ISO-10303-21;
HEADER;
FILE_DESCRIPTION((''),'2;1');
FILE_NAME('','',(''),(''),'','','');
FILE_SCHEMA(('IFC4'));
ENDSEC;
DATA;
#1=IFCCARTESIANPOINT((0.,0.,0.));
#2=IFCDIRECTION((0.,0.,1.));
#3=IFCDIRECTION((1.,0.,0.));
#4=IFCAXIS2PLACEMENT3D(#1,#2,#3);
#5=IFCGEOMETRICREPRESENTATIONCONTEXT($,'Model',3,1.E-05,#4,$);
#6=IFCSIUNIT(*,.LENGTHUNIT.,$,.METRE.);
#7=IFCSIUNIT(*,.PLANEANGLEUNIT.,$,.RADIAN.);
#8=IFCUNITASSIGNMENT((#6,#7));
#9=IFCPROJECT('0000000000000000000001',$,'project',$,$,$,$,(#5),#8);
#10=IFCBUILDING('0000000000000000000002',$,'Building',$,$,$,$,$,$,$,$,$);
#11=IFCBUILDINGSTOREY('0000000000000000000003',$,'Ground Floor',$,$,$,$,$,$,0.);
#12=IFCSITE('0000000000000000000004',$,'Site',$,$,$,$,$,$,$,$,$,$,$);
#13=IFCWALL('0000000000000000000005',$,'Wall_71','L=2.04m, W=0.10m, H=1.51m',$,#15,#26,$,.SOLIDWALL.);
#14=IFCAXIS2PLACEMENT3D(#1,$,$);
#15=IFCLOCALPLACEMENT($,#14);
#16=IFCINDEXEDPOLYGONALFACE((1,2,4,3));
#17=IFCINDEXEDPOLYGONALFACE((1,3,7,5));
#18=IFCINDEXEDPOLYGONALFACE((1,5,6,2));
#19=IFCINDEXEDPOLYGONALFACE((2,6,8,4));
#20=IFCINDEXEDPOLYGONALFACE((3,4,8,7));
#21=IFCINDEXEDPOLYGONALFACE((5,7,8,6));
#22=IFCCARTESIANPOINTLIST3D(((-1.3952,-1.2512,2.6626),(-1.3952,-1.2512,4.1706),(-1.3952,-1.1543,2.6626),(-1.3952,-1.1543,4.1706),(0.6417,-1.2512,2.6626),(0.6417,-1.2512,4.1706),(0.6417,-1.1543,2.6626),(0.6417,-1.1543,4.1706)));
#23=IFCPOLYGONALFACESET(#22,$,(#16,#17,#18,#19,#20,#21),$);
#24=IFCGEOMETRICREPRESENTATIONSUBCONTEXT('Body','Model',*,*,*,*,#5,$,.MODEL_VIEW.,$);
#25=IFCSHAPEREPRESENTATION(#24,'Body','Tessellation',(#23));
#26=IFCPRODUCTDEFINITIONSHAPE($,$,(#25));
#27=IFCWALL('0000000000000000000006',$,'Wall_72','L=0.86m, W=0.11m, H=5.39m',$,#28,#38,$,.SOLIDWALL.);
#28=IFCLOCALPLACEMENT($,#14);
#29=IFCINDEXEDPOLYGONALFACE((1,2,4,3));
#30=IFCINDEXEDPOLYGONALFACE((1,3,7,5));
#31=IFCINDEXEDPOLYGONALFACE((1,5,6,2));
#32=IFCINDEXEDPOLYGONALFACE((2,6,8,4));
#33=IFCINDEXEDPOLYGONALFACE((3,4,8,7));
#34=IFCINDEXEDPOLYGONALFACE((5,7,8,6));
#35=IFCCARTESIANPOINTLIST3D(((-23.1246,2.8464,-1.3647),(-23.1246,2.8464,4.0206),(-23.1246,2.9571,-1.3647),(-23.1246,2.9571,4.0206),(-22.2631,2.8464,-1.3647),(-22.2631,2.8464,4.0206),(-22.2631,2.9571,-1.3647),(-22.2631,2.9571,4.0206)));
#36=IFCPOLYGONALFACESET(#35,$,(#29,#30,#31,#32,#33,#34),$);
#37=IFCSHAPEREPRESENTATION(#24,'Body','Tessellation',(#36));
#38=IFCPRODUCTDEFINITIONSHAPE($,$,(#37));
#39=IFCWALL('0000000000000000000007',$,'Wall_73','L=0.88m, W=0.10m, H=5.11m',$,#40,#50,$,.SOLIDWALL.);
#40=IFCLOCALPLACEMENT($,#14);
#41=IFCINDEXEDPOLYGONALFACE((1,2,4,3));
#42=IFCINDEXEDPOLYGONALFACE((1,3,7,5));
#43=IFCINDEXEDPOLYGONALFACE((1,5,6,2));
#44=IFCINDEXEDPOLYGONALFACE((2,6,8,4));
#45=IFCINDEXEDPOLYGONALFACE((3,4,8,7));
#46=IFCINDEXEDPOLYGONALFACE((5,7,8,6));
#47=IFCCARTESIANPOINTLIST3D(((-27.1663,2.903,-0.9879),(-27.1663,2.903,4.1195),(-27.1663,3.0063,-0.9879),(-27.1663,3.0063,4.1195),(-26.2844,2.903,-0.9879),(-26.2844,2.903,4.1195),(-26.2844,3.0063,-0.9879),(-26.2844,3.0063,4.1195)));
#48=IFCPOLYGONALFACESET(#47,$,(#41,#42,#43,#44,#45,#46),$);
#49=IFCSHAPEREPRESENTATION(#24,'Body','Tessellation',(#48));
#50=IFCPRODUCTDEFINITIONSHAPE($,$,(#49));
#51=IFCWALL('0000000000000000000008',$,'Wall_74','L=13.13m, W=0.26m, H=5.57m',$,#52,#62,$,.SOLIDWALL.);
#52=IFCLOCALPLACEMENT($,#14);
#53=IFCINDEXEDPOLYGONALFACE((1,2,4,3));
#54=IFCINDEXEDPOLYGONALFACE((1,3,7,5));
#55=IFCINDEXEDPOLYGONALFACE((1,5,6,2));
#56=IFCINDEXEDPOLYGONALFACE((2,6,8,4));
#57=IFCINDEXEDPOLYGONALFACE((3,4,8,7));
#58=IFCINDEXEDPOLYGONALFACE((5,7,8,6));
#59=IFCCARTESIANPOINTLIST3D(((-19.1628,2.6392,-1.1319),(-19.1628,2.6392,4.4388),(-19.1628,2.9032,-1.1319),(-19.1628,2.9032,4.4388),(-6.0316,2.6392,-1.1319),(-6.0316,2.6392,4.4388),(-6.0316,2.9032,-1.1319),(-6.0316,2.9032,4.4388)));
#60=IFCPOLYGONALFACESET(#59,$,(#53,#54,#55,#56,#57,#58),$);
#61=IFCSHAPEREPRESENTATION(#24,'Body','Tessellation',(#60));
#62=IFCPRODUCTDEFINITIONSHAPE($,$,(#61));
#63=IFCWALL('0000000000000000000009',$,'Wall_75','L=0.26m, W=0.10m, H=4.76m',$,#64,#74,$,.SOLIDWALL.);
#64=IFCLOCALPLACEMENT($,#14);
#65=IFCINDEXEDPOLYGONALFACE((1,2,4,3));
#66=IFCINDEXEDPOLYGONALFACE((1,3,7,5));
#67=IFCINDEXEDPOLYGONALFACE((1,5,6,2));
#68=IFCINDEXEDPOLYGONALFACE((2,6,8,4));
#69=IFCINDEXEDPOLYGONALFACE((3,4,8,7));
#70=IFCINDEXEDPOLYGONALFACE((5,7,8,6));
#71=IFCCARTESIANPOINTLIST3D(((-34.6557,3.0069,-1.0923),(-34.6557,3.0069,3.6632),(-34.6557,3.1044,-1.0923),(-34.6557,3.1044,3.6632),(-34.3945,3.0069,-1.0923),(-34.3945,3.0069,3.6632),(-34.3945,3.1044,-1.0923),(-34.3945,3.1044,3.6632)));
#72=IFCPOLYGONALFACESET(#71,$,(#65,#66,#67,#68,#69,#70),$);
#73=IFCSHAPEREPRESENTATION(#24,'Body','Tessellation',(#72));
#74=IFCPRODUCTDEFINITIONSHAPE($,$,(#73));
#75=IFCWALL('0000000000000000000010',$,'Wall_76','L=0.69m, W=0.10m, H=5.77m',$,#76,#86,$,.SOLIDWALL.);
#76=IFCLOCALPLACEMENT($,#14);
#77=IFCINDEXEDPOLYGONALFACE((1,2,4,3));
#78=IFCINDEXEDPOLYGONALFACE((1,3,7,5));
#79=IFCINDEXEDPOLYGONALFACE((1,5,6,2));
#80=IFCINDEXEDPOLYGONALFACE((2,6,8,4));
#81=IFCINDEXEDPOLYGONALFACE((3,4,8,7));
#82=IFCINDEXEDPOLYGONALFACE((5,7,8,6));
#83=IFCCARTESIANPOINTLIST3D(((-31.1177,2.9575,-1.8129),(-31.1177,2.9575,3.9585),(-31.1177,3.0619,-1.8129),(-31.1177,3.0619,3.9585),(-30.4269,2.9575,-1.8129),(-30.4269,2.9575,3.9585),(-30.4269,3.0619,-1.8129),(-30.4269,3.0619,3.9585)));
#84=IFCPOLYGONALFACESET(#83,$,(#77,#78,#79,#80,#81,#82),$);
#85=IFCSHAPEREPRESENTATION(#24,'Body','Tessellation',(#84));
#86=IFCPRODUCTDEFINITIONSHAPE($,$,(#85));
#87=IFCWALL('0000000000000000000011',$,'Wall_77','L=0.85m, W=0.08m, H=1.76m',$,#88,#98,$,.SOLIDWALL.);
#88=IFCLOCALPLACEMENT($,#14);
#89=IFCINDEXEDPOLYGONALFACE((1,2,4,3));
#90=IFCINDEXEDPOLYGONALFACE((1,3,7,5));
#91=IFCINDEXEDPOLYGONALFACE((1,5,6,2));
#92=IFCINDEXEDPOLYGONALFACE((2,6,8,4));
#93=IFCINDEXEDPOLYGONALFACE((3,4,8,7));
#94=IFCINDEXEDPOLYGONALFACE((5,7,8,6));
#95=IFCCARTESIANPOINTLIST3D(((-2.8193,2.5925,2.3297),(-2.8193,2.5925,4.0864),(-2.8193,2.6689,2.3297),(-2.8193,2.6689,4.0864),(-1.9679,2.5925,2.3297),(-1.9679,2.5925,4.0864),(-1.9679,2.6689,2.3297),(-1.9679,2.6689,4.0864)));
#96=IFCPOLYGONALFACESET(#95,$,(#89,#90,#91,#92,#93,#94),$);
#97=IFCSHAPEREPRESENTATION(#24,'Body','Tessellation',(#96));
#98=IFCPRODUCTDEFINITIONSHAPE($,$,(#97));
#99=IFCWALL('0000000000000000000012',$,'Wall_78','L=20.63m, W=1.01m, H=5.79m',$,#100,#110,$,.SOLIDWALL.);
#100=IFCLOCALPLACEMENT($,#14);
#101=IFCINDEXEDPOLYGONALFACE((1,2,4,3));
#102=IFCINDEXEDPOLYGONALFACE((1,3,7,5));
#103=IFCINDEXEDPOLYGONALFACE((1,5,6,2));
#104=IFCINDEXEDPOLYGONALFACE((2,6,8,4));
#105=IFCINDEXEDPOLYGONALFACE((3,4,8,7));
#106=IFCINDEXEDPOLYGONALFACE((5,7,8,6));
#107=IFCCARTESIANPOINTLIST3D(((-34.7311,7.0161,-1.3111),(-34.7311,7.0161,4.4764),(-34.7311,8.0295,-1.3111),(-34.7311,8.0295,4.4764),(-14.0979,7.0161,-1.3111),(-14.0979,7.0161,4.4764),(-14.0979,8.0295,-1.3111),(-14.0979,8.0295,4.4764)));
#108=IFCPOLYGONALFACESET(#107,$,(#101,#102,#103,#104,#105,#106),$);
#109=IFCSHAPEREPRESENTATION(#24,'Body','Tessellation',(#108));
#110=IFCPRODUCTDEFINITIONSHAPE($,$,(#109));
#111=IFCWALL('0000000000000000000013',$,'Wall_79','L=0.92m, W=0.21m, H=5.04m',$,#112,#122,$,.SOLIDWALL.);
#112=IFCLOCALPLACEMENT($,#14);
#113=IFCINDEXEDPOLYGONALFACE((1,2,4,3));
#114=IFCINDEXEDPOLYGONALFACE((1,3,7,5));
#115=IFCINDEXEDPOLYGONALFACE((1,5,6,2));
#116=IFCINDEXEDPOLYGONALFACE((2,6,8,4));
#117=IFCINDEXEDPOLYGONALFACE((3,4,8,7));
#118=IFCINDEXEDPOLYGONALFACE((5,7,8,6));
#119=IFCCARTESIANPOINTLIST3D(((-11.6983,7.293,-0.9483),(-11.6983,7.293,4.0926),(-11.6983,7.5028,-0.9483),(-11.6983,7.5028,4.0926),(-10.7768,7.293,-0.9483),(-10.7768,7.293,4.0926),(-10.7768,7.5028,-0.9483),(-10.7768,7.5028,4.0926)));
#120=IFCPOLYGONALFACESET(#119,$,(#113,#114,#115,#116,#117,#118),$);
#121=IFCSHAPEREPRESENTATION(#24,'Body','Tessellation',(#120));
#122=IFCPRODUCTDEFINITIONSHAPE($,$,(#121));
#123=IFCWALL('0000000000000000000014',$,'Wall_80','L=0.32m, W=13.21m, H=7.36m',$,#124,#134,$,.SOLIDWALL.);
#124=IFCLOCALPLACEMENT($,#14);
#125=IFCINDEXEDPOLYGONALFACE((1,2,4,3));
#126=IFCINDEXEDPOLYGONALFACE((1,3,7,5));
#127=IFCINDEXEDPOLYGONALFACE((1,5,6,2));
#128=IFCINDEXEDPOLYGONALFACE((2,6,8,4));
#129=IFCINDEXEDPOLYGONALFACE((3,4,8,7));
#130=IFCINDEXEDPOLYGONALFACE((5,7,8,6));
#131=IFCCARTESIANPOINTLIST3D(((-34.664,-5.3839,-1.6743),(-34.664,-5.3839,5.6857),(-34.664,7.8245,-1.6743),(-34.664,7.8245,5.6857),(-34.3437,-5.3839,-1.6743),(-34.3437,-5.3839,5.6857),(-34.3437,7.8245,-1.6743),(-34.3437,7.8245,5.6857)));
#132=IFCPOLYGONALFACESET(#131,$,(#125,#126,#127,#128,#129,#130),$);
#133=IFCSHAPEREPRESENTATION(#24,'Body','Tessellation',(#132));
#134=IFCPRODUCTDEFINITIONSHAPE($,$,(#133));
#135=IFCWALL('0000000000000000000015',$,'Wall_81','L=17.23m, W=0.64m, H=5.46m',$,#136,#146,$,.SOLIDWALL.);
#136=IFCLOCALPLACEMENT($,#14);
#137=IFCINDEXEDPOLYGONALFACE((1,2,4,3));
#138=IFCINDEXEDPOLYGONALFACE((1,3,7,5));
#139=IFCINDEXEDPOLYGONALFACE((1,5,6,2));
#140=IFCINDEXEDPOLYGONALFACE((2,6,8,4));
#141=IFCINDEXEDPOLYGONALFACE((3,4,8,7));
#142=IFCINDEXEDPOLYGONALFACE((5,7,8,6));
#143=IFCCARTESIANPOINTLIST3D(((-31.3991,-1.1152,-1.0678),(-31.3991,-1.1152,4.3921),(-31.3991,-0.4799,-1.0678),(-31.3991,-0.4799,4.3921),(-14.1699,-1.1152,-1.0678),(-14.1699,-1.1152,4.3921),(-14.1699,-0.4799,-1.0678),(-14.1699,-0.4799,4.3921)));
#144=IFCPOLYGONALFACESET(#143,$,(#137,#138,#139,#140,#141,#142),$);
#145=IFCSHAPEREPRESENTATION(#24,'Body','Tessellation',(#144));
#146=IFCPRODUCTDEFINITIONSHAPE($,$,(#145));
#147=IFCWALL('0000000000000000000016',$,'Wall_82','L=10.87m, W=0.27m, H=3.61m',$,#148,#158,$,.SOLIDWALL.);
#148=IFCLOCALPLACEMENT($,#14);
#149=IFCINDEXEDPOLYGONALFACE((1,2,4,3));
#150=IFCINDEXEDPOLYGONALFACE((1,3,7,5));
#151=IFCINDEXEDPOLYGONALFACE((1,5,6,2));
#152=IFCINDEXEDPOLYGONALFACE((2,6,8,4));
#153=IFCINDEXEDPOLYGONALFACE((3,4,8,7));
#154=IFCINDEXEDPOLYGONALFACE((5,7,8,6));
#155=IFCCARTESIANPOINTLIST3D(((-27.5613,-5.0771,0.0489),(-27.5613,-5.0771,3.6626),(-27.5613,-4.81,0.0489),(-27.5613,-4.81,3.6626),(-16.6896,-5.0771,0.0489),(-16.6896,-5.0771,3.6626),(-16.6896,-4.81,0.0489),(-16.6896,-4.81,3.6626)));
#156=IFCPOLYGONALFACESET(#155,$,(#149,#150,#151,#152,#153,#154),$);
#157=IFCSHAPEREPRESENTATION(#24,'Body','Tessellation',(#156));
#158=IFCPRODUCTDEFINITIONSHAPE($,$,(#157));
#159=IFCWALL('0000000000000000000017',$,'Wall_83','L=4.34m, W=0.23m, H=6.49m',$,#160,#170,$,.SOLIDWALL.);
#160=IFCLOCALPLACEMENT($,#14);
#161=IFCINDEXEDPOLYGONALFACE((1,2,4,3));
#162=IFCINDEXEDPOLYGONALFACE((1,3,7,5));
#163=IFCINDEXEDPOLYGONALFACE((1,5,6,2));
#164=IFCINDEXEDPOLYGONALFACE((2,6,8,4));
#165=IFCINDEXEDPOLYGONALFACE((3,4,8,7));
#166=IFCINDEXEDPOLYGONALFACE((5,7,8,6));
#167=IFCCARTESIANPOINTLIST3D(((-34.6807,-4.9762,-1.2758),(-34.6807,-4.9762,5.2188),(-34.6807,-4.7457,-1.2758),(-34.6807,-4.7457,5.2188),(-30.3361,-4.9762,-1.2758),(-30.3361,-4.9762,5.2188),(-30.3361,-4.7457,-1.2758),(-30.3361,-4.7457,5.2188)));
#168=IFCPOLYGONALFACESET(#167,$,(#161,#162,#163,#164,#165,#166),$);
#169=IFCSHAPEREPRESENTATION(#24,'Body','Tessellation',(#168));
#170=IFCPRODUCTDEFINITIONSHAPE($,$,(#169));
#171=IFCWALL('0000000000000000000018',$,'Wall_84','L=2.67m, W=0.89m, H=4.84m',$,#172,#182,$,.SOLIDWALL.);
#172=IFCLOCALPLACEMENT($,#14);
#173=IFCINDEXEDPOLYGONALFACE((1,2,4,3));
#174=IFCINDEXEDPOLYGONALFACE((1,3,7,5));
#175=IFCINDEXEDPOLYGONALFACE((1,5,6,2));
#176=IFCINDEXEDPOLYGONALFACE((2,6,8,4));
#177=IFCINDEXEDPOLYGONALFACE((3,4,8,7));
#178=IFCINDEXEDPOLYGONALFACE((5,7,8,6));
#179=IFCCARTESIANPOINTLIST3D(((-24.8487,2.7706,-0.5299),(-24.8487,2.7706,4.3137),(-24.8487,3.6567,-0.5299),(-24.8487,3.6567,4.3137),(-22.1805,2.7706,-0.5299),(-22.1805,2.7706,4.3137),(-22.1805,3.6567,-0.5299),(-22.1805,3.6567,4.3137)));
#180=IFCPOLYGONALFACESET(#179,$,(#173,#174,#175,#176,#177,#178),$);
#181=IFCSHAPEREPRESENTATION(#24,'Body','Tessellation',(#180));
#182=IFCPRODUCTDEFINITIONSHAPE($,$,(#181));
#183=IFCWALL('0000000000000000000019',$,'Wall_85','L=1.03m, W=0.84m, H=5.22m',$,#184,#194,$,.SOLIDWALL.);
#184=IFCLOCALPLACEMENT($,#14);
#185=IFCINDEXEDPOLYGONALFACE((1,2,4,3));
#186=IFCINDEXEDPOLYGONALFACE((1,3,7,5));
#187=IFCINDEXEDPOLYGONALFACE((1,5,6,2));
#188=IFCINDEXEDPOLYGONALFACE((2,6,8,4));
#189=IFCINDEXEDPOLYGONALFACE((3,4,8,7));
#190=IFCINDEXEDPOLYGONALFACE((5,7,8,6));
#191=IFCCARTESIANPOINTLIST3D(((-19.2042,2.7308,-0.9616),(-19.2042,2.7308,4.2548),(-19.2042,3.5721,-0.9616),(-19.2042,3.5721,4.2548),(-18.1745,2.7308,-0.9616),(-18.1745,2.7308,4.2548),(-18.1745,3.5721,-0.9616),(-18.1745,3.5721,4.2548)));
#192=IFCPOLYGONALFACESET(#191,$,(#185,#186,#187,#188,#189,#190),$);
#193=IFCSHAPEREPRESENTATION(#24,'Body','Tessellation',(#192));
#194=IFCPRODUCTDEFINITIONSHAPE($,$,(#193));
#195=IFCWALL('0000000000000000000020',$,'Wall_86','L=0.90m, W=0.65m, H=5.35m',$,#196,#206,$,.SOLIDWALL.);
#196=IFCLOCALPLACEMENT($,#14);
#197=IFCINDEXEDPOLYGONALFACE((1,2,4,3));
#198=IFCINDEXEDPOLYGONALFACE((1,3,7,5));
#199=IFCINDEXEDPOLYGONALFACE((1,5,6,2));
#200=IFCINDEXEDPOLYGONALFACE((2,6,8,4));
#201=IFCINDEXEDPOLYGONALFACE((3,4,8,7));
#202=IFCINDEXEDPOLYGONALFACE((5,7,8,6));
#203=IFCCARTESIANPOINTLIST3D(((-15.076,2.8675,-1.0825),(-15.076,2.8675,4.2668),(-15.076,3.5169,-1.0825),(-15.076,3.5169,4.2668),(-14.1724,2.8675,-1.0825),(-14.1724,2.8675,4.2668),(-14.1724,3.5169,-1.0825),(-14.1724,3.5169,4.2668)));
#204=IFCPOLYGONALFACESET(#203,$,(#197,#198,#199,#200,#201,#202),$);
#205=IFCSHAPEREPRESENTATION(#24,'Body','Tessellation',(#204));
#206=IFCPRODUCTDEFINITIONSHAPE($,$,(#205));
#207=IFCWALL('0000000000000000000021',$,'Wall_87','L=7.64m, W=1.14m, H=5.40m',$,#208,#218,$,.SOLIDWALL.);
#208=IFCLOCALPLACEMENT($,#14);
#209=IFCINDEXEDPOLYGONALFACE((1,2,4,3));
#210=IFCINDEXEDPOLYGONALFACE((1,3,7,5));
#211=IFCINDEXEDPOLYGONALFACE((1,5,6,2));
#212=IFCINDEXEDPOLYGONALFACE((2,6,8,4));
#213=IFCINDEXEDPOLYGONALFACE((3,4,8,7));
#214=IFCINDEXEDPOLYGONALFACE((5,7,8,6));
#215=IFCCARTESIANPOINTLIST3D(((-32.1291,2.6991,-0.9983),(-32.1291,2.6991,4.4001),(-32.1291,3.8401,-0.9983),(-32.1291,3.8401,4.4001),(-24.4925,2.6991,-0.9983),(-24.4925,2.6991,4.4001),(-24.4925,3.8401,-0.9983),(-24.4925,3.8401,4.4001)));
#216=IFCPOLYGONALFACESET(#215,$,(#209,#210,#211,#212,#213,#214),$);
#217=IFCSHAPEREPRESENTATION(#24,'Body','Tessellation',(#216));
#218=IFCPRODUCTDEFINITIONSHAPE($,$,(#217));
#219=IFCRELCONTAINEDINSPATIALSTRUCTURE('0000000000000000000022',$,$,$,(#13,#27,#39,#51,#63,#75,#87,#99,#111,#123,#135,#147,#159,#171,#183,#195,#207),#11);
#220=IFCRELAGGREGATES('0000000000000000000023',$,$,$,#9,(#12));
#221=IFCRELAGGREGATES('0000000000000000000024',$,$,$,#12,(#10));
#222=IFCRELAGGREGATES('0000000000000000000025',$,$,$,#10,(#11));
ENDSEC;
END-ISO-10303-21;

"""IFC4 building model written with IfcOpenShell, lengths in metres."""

from ifc_helpers import new_model, si_unit, frame, origin_with_axes, origin_2d, context, subcontext, project, spatial, rectangle, extrude, element, save


model = new_model("IFC4")

# Units and contexts
model_context = context("Model", 3, precision=1e-05, world=origin_with_axes())
body_context = subcontext(model_context, "Body", "Model", "MODEL_VIEW")
ifc_project = project(units=[si_unit("LENGTHUNIT", "METRE"), si_unit("PLANEANGLEUNIT", "RADIAN")], contexts=[model_context])

# Site, building, storey
site = spatial("IfcSite", under=ifc_project, Name="Site")
building = spatial("IfcBuilding", under=site, Name="Building")
storey = spatial("IfcBuildingStorey", under=building, Name="Ground Floor", Elevation=0.0)

# Walls
element("IfcWall", 1, inside=storey, Name="Wall_71", Description="L=2.04m, W=0.10m, H=1.51m", PredefinedType="SOLIDWALL", context=body_context, shape_type="SweptSolid", body=[
    extrude(rectangle(XDim=2.037, YDim=0.097, at=origin_2d()), frame((-0.3768, -1.2027, 2.6626), z_axis=(0.0, 0.0, 1.0), x_axis=(1.0, 0.0, 0.0)), (0.0, 0.0, 1.0), 1.5081),
])
element("IfcWall", 2, inside=storey, Name="Wall_72", Description="L=0.86m, W=0.11m, H=5.39m", PredefinedType="SOLIDWALL", context=body_context, shape_type="SweptSolid", body=[
    extrude(rectangle(XDim=0.8615, YDim=0.1107, at=origin_2d()), frame((-22.6939, 2.9017, -1.3647), z_axis=(0.0, 0.0, 1.0), x_axis=(1.0, 0.0, 0.0)), (0.0, 0.0, 1.0), 5.3853),
])
element("IfcWall", 3, inside=storey, Name="Wall_73", Description="L=0.88m, W=0.10m, H=5.11m", PredefinedType="SOLIDWALL", context=body_context, shape_type="SweptSolid", body=[
    extrude(rectangle(XDim=0.8819, YDim=0.1033, at=origin_2d()), frame((-26.7254, 2.9547, -0.9879), z_axis=(0.0, 0.0, 1.0), x_axis=(1.0, 0.0, 0.0)), (0.0, 0.0, 1.0), 5.1075),
])
element("IfcWall", 4, inside=storey, Name="Wall_74", Description="L=13.13m, W=0.26m, H=5.57m", PredefinedType="SOLIDWALL", context=body_context, shape_type="SweptSolid", body=[
    extrude(rectangle(XDim=13.1312, YDim=0.264, at=origin_2d()), frame((-12.5972, 2.7712, -1.1319), z_axis=(0.0, 0.0, 1.0), x_axis=(1.0, 0.0, 0.0)), (0.0, 0.0, 1.0), 5.5707),
])
element("IfcWall", 5, inside=storey, Name="Wall_75", Description="L=0.26m, W=0.10m, H=4.76m", PredefinedType="SOLIDWALL", context=body_context, shape_type="SweptSolid", body=[
    extrude(rectangle(XDim=0.2612, YDim=0.0975, at=origin_2d()), frame((-34.5251, 3.0556, -1.0923), z_axis=(0.0, 0.0, 1.0), x_axis=(1.0, 0.0, 0.0)), (0.0, 0.0, 1.0), 4.7555),
])
element("IfcWall", 6, inside=storey, Name="Wall_76", Description="L=0.69m, W=0.10m, H=5.77m", PredefinedType="SOLIDWALL", context=body_context, shape_type="SweptSolid", body=[
    extrude(rectangle(XDim=0.6907, YDim=0.1044, at=origin_2d()), frame((-30.7723, 3.0097, -1.8129), z_axis=(0.0, 0.0, 1.0), x_axis=(1.0, 0.0, 0.0)), (0.0, 0.0, 1.0), 5.7715),
])
element("IfcWall", 7, inside=storey, Name="Wall_77", Description="L=0.85m, W=0.08m, H=1.76m", PredefinedType="SOLIDWALL", context=body_context, shape_type="SweptSolid", body=[
    extrude(rectangle(XDim=0.8514, YDim=0.0764, at=origin_2d()), frame((-2.3936, 2.6307, 2.3297), z_axis=(0.0, 0.0, 1.0), x_axis=(1.0, 0.0, 0.0)), (0.0, 0.0, 1.0), 1.7568),
])
element("IfcWall", 8, inside=storey, Name="Wall_78", Description="L=20.63m, W=1.01m, H=5.79m", PredefinedType="SOLIDWALL", context=body_context, shape_type="SweptSolid", body=[
    extrude(rectangle(XDim=20.6332, YDim=1.0133, at=origin_2d()), frame((-24.4145, 7.5228, -1.3111), z_axis=(0.0, 0.0, 1.0), x_axis=(1.0, 0.0, 0.0)), (0.0, 0.0, 1.0), 5.7875),
])
element("IfcWall", 9, inside=storey, Name="Wall_79", Description="L=0.92m, W=0.21m, H=5.04m", PredefinedType="SOLIDWALL", context=body_context, shape_type="SweptSolid", body=[
    extrude(rectangle(XDim=0.9215, YDim=0.2097, at=origin_2d()), frame((-11.2375, 7.3979, -0.9483), z_axis=(0.0, 0.0, 1.0), x_axis=(1.0, 0.0, 0.0)), (0.0, 0.0, 1.0), 5.0409),
])
element("IfcWall", 10, inside=storey, Name="Wall_80", Description="L=0.32m, W=13.21m, H=7.36m", PredefinedType="SOLIDWALL", context=body_context, shape_type="SweptSolid", body=[
    extrude(rectangle(XDim=0.3203, YDim=13.2084, at=origin_2d()), frame((-34.5038, 1.2203, -1.6743), z_axis=(0.0, 0.0, 1.0), x_axis=(1.0, 0.0, 0.0)), (0.0, 0.0, 1.0), 7.36),
])
element("IfcWall", 11, inside=storey, Name="Wall_81", Description="L=17.23m, W=0.64m, H=5.46m", PredefinedType="SOLIDWALL", context=body_context, shape_type="SweptSolid", body=[
    extrude(rectangle(XDim=17.2292, YDim=0.6353, at=origin_2d()), frame((-22.7845, -0.7975, -1.0678), z_axis=(0.0, 0.0, 1.0), x_axis=(1.0, 0.0, 0.0)), (0.0, 0.0, 1.0), 5.4599),
])
element("IfcWall", 12, inside=storey, Name="Wall_82", Description="L=10.87m, W=0.27m, H=3.61m", PredefinedType="SOLIDWALL", context=body_context, shape_type="SweptSolid", body=[
    extrude(rectangle(XDim=10.8717, YDim=0.267, at=origin_2d()), frame((-22.1254, -4.9436, 0.0489), z_axis=(0.0, 0.0, 1.0), x_axis=(1.0, 0.0, 0.0)), (0.0, 0.0, 1.0), 3.6137),
])
element("IfcWall", 13, inside=storey, Name="Wall_83", Description="L=4.34m, W=0.23m, H=6.49m", PredefinedType="SOLIDWALL", context=body_context, shape_type="SweptSolid", body=[
    extrude(rectangle(XDim=4.3446, YDim=0.2305, at=origin_2d()), frame((-32.5084, -4.861, -1.2758), z_axis=(0.0, 0.0, 1.0), x_axis=(1.0, 0.0, 0.0)), (0.0, 0.0, 1.0), 6.4946),
])
element("IfcWall", 14, inside=storey, Name="Wall_84", Description="L=2.67m, W=0.89m, H=4.84m", PredefinedType="SOLIDWALL", context=body_context, shape_type="SweptSolid", body=[
    extrude(rectangle(XDim=2.6682, YDim=0.8861, at=origin_2d()), frame((-23.5146, 3.2136, -0.5299), z_axis=(0.0, 0.0, 1.0), x_axis=(1.0, 0.0, 0.0)), (0.0, 0.0, 1.0), 4.8436),
])
element("IfcWall", 15, inside=storey, Name="Wall_85", Description="L=1.03m, W=0.84m, H=5.22m", PredefinedType="SOLIDWALL", context=body_context, shape_type="SweptSolid", body=[
    extrude(rectangle(XDim=1.0297, YDim=0.8412, at=origin_2d()), frame((-18.6894, 3.1514, -0.9616), z_axis=(0.0, 0.0, 1.0), x_axis=(1.0, 0.0, 0.0)), (0.0, 0.0, 1.0), 5.2164),
])
element("IfcWall", 16, inside=storey, Name="Wall_86", Description="L=0.90m, W=0.65m, H=5.35m", PredefinedType="SOLIDWALL", context=body_context, shape_type="SweptSolid", body=[
    extrude(rectangle(XDim=0.9035, YDim=0.6494, at=origin_2d()), frame((-14.6242, 3.1922, -1.0825), z_axis=(0.0, 0.0, 1.0), x_axis=(1.0, 0.0, 0.0)), (0.0, 0.0, 1.0), 5.3493),
])
element("IfcWall", 17, inside=storey, Name="Wall_87", Description="L=7.64m, W=1.14m, H=5.40m", PredefinedType="SOLIDWALL", context=body_context, shape_type="SweptSolid", body=[
    extrude(rectangle(XDim=7.6367, YDim=1.1411, at=origin_2d()), frame((-28.3108, 3.2696, -0.9983), z_axis=(0.0, 0.0, 1.0), x_axis=(1.0, 0.0, 0.0)), (0.0, 0.0, 1.0), 5.3984),
])

save(model, "model.ifc")
